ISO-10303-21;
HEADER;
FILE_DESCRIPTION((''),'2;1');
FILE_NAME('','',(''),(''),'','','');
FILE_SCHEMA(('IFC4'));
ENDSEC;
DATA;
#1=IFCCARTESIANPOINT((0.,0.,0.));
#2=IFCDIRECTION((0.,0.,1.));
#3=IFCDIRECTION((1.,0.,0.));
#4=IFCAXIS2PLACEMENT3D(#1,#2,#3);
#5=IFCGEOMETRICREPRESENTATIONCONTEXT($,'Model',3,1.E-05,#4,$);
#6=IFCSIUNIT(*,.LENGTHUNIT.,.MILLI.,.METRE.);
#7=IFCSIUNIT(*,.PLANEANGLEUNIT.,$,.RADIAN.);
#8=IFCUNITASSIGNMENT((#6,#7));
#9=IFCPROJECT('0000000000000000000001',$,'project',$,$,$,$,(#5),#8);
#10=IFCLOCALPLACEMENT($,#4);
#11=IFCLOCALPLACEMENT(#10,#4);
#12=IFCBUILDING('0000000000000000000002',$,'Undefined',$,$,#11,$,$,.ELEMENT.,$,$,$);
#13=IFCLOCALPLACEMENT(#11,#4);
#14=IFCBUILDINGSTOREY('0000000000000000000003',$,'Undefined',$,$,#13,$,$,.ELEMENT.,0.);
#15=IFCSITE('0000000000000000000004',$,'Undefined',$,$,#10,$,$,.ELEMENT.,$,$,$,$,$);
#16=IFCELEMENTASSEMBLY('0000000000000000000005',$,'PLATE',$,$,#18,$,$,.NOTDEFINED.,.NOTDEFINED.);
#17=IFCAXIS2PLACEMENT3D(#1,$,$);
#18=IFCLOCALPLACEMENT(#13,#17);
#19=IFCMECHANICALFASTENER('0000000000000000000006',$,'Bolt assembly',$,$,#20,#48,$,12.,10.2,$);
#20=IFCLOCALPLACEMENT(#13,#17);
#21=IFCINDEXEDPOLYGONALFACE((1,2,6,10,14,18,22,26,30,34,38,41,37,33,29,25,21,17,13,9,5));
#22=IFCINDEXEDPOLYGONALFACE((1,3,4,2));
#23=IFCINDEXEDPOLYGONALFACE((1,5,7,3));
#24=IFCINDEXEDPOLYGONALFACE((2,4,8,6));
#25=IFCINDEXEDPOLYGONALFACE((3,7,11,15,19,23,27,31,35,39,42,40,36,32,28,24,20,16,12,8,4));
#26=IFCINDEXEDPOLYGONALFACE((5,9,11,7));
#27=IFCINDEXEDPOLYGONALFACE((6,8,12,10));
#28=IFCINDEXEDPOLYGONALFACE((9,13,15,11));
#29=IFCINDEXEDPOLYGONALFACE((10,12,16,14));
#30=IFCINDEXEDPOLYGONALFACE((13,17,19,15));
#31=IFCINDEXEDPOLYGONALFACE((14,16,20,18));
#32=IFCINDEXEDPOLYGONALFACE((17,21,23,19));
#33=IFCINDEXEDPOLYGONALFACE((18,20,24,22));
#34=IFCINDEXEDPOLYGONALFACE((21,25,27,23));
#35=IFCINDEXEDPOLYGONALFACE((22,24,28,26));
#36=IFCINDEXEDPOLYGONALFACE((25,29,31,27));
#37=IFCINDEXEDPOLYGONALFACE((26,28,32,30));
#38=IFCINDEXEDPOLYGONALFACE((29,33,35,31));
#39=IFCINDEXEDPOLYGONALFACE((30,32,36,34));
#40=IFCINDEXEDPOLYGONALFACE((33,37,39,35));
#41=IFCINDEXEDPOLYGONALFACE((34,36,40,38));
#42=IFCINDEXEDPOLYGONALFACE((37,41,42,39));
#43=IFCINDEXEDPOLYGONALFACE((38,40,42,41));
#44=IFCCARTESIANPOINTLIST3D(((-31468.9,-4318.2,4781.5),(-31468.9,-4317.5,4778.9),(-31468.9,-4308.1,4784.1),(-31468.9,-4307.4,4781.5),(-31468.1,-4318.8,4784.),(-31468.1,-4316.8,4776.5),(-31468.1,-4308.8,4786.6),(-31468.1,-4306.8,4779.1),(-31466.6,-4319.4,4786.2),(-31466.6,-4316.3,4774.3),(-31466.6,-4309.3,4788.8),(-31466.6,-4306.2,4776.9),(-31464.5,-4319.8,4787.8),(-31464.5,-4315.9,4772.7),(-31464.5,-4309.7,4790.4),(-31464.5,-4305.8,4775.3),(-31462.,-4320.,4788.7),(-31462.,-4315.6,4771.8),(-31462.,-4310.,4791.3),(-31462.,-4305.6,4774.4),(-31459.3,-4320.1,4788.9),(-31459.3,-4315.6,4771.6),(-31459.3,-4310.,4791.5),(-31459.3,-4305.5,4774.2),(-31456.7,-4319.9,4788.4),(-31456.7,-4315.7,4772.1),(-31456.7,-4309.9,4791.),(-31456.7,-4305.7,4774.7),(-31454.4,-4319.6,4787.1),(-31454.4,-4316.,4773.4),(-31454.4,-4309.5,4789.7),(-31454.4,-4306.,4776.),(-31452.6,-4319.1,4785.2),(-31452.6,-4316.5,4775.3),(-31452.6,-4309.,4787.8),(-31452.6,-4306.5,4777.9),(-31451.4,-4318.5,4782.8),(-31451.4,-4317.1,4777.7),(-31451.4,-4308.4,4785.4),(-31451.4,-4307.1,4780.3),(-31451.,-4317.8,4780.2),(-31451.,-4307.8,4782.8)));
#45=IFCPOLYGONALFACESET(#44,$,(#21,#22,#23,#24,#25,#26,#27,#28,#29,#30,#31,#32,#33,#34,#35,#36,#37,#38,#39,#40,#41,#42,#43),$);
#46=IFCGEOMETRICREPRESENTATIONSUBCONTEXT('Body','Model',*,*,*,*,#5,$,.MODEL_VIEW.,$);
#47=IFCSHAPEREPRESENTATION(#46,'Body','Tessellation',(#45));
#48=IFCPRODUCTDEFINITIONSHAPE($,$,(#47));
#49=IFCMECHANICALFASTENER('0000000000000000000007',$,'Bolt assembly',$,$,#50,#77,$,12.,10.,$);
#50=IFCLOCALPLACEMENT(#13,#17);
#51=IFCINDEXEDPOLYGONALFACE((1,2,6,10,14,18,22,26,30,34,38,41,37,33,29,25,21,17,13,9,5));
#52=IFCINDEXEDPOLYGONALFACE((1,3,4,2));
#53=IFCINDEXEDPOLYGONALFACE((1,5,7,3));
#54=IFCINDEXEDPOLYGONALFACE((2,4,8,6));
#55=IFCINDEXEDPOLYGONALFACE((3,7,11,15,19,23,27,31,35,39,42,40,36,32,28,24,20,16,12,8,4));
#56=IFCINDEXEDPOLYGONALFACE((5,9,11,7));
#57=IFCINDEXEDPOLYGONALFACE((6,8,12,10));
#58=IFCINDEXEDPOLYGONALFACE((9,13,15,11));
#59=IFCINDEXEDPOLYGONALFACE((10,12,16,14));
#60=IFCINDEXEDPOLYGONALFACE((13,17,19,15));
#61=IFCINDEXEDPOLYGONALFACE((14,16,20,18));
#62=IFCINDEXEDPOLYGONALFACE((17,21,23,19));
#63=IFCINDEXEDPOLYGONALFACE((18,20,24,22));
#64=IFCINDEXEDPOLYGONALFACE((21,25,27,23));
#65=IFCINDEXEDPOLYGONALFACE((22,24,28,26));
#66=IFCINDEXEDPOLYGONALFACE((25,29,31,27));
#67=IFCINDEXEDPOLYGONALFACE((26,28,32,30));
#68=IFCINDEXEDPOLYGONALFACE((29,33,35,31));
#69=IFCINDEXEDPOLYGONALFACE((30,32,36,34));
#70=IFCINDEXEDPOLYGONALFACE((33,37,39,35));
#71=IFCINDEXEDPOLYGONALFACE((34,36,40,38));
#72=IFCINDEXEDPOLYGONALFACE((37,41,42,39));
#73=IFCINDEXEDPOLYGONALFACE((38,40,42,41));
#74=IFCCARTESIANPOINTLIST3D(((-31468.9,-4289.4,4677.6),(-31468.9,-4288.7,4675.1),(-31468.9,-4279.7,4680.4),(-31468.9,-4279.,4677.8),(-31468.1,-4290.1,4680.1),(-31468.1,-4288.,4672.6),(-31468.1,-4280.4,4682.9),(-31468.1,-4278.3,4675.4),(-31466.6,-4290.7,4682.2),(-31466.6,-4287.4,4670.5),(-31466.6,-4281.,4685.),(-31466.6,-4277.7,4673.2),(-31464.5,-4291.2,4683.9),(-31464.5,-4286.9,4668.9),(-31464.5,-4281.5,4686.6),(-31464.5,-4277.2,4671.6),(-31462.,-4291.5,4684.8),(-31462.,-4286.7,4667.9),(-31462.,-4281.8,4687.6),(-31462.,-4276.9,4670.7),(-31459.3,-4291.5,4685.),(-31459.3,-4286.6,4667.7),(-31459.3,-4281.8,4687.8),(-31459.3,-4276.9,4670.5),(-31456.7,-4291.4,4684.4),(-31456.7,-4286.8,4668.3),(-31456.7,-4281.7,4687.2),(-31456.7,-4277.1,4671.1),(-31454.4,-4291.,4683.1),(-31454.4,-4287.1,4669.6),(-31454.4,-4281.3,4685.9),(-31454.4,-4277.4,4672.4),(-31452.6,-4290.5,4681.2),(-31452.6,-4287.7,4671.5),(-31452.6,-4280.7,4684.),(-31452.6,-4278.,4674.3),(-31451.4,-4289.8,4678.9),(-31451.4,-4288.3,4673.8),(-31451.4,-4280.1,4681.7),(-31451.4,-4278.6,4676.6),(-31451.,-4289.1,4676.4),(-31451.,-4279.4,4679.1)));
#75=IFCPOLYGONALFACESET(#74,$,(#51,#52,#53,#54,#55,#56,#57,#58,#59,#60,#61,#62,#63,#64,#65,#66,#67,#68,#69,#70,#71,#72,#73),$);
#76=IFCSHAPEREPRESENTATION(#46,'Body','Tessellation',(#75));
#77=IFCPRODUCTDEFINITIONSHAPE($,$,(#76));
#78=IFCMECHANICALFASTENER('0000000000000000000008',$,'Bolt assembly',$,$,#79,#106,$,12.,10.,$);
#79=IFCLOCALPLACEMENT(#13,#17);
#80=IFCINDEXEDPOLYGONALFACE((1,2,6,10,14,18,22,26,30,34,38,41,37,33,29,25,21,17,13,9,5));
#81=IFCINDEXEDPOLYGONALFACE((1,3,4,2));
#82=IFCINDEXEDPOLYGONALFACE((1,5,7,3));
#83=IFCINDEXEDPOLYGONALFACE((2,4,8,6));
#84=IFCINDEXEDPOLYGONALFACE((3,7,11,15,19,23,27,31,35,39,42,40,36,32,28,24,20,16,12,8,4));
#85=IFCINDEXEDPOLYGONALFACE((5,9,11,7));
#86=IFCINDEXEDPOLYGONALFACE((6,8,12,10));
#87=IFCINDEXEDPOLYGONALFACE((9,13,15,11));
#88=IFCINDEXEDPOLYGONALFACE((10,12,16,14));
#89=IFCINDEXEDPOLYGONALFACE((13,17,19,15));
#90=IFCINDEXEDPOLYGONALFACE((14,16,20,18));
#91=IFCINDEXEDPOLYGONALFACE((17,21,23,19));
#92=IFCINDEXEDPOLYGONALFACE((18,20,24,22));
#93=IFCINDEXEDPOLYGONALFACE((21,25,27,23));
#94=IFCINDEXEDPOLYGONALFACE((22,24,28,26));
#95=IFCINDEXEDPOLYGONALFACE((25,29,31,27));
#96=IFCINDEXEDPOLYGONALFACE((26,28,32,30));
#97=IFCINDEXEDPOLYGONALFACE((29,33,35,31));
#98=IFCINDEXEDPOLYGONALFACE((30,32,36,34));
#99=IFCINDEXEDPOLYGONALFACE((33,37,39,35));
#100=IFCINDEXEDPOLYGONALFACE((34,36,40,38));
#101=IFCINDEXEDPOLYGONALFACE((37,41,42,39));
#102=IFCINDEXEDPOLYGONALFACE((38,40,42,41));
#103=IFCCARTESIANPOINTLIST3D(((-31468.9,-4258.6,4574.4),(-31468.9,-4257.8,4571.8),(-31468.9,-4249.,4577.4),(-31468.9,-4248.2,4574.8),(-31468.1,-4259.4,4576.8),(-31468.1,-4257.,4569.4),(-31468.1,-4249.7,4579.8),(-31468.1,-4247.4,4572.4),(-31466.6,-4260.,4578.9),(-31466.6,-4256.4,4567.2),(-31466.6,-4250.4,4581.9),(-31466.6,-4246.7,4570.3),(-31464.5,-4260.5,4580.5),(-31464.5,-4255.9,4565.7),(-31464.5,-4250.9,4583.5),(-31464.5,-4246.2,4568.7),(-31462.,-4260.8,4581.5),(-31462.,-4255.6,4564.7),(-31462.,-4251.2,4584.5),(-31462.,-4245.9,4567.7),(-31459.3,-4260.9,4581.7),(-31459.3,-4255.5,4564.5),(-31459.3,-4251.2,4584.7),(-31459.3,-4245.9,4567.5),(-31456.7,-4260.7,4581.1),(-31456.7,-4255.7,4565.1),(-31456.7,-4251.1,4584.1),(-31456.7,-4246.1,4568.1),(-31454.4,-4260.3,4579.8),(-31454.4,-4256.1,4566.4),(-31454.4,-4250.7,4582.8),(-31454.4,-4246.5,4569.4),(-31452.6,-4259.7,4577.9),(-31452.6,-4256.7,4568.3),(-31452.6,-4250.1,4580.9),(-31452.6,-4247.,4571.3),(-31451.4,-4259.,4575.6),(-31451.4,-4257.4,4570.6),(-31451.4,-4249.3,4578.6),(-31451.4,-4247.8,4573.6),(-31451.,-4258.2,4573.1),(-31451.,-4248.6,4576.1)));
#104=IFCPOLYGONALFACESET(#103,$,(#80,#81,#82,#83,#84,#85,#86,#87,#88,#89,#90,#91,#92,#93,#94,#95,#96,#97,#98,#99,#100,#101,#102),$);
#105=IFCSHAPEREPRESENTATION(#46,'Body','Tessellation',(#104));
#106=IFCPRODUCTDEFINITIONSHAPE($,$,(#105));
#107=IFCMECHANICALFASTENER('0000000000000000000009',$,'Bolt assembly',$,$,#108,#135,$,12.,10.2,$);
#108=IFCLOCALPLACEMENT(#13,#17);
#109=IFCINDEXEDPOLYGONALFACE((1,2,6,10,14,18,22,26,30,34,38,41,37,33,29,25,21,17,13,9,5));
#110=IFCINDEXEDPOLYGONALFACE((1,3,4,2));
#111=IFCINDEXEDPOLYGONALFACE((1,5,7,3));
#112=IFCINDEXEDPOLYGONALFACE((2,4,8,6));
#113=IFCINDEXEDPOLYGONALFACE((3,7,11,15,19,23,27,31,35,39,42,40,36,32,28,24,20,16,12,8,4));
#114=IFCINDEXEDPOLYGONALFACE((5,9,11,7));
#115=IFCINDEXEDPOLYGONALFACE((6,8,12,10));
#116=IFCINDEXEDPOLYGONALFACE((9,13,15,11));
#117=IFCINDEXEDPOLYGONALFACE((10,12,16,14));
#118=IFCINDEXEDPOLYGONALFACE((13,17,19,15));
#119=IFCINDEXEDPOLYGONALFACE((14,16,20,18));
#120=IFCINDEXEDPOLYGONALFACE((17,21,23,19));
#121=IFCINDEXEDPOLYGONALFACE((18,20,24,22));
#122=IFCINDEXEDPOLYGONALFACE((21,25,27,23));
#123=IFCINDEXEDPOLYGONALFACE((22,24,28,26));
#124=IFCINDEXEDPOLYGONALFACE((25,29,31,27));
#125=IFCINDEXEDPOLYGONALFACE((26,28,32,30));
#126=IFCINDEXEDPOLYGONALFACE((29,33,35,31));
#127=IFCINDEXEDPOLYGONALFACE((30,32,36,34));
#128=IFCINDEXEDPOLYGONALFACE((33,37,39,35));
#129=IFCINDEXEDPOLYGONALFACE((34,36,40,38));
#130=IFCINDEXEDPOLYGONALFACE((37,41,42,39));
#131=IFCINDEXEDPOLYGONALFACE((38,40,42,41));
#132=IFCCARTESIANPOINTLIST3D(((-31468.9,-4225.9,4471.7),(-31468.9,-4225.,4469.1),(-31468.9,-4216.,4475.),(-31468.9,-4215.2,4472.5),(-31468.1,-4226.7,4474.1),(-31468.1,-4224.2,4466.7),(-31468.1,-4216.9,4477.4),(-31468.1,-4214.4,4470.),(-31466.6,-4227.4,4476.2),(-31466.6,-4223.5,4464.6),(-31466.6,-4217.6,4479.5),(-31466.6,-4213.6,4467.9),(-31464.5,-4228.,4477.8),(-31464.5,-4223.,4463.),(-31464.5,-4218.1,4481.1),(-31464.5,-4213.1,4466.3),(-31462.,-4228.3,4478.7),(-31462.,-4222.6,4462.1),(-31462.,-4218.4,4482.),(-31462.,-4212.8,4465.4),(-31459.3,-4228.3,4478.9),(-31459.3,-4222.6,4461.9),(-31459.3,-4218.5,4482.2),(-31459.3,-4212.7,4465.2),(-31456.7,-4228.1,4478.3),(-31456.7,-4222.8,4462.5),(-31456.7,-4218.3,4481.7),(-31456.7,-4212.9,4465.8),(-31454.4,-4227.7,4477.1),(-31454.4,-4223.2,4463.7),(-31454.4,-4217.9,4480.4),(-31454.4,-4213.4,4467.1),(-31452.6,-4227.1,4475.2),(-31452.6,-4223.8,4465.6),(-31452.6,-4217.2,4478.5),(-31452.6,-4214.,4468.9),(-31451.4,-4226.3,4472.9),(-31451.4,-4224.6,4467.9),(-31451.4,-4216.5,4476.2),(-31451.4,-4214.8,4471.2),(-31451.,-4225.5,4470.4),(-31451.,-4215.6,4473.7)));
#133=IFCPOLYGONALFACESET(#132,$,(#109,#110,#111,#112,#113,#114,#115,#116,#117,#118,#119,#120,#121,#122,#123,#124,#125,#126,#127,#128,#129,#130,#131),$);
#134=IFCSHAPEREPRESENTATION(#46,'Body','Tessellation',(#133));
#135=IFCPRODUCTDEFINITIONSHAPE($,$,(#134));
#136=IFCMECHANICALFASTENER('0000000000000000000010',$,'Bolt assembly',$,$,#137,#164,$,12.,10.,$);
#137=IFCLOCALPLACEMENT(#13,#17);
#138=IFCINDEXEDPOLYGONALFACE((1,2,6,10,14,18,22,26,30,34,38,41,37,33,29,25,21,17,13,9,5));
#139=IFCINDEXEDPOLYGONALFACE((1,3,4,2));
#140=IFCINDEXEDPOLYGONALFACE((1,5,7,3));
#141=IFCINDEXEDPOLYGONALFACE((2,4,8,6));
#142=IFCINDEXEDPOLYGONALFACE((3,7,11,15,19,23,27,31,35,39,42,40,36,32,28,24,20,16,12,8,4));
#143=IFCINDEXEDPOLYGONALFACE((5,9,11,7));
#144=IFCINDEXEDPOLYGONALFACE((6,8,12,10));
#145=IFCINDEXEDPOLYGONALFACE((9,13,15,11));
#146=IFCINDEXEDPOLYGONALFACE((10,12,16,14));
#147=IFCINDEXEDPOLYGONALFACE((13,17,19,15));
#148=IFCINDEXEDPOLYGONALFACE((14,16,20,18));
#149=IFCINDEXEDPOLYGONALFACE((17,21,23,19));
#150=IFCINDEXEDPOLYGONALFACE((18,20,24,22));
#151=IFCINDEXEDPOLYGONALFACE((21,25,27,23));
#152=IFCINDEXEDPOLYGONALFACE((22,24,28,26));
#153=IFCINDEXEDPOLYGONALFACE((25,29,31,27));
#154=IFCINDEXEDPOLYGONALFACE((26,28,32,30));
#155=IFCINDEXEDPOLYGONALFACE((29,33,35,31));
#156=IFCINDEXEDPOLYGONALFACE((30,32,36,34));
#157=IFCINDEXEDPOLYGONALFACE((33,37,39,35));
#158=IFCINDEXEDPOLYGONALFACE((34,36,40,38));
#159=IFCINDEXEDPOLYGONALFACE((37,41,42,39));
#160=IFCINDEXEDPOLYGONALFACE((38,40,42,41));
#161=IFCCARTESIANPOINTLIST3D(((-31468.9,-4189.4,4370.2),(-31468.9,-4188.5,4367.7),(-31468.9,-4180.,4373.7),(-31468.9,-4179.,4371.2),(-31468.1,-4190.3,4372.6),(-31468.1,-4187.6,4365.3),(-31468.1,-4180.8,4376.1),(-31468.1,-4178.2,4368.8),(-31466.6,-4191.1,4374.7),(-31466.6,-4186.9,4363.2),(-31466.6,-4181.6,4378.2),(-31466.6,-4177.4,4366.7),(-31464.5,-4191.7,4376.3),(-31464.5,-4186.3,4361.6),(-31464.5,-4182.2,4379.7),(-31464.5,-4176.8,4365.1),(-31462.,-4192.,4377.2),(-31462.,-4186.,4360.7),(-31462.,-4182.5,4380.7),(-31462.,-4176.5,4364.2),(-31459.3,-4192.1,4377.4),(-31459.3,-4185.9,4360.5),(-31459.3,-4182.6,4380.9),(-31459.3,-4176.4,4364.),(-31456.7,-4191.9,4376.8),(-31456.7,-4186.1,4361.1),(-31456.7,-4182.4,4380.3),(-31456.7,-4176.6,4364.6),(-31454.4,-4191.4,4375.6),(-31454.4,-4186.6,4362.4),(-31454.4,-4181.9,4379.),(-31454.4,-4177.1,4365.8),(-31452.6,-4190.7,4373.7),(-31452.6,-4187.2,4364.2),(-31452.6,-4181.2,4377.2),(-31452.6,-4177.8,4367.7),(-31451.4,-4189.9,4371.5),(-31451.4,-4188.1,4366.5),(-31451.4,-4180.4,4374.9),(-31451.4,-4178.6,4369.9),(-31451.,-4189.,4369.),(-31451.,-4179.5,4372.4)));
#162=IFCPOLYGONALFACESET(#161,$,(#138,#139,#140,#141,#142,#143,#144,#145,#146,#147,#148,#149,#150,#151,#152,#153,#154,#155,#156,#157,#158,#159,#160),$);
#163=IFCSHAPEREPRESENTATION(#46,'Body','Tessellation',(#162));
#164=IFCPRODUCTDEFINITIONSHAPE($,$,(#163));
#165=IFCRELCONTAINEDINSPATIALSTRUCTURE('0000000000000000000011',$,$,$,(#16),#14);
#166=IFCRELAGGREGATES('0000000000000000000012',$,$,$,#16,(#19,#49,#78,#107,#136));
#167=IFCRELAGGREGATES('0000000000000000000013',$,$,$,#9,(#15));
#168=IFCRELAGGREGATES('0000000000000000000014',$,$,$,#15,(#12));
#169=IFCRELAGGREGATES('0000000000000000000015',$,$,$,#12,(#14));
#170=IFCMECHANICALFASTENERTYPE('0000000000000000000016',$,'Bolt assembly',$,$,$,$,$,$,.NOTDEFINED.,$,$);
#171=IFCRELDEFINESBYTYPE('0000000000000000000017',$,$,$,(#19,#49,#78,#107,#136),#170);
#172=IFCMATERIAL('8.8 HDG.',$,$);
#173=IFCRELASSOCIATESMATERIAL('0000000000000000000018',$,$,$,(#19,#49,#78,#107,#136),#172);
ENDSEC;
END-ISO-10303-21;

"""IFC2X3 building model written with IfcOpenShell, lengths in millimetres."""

from ifc_helpers import new_model, si_unit, frame, origin_with_axes, origin_2d_with_axis, place, context, subcontext, project, spatial, circle, extrude, source, transform, mapped, material, type_object, element, aggregate, save


model = new_model("IFC2X3")

# Units and contexts
model_context = context("Model", 3, precision=1e-05, world=origin_with_axes())
body_context = subcontext(model_context, "Body", "Model", "MODEL_VIEW")
ifc_project = project(units=[si_unit("LENGTHUNIT", "METRE", prefix="MILLI"), si_unit("PLANEANGLEUNIT", "RADIAN")], contexts=[model_context])

# Site, building, storey
site_placement = place(None, origin_with_axes())
site = spatial("IfcSite", under=ifc_project, at=site_placement, Name="Undefined", CompositionType="ELEMENT")
building_placement = place(site_placement, origin_with_axes())
building = spatial("IfcBuilding", under=site, at=building_placement, Name="Undefined", CompositionType="ELEMENT")
storey_placement = place(building_placement, origin_with_axes())
storey = spatial("IfcBuildingStorey", under=building, at=storey_placement, Name="Undefined", CompositionType="ELEMENT", Elevation=0.0)

# Element assembly
assembly_1_placement = place(storey_placement, origin_with_axes())
assembly_1 = element("IfcElementAssembly", 1, at=assembly_1_placement, inside=storey, Name="PLATE", AssemblyPlace="NOTDEFINED", PredefinedType="NOTDEFINED")

# Shared definitions
mechanical_fastener_type = type_object("IfcMechanicalFastenerType", Name="Bolt assembly")

# Mechanical fasteners
ifc_material_1 = material(Name="8.8 HDG.")
shared_shape_1 = source(origin_with_axes(), body_context, "Body", "SweptSolid", [
    extrude(circle(Radius=9.0, at=origin_2d_with_axis()), frame((0.0, 0.3, 0.0), z_axis=(0.0, 1.0, 0.0), x_axis=(1.0, 0.0, 0.0)), (0.0, 0.0, 1.0), 10.4),
])
mechanical_fastener_1_placement = place(assembly_1_placement, frame((-31460.0, -4318.1, 4780.2), z_axis=(0.000001, -0.25103, 0.967979), x_axis=(1.0, 0.0, -0.000001)))
mechanical_fastener_1 = element("IfcMechanicalFastener", 2, at=mechanical_fastener_1_placement, type_object=mechanical_fastener_type, material=ifc_material_1, Name="Bolt assembly", NominalDiameter=12.0, NominalLength=10.2, context=body_context, shape_type="MappedRepresentation", body=[
    mapped(shared_shape_1, transform((0.0, 0.0, 0.0))),
])
shared_shape_2 = source(origin_with_axes(), body_context, "Body", "SweptSolid", [
    extrude(circle(Radius=9.0, at=origin_2d_with_axis()), frame((0.0, 0.8, 0.0), z_axis=(0.0, 1.0, 0.0), x_axis=(1.0, 0.0, 0.0)), (0.0, 0.0, 1.0), 10.1),
])
mechanical_fastener_2_placement = place(assembly_1_placement, frame((-31460.0, -4289.8, 4676.2), z_axis=(0.000001, -0.274347, 0.961631), x_axis=(1.0, 0.0, -0.000001)))
mechanical_fastener_2 = element("IfcMechanicalFastener", 3, at=mechanical_fastener_2_placement, type_object=mechanical_fastener_type, material=ifc_material_1, Name="Bolt assembly", NominalDiameter=12.0, NominalLength=10.0, context=body_context, shape_type="MappedRepresentation", body=[
    mapped(shared_shape_2, transform((0.0, 0.0, 0.0))),
])
shared_shape_3 = source(origin_with_axes(), body_context, "Body", "SweptSolid", [
    extrude(circle(Radius=9.0, at=origin_2d_with_axis()), frame((0.0, 0.8, 0.0), z_axis=(0.0, 1.0, 0.0), x_axis=(1.0, 0.0, 0.0)), (0.0, 0.0, 1.0), 10.1),
])
mechanical_fastener_3_placement = place(assembly_1_placement, frame((-31460.0, -4259.0, 4572.9), z_axis=(0.000001, -0.297503, 0.954721), x_axis=(1.0, 0.0, -0.000001)))
mechanical_fastener_3 = element("IfcMechanicalFastener", 4, at=mechanical_fastener_3_placement, type_object=mechanical_fastener_type, material=ifc_material_1, Name="Bolt assembly", NominalDiameter=12.0, NominalLength=10.0, context=body_context, shape_type="MappedRepresentation", body=[
    mapped(shared_shape_3, transform((0.0, 0.0, 0.0))),
])
shared_shape_4 = source(origin_with_axes(), body_context, "Body", "SweptSolid", [
    extrude(circle(Radius=9.0, at=origin_2d_with_axis()), frame((0.0, 0.2, 0.0), z_axis=(0.0, 1.0, 0.0), x_axis=(1.0, 0.0, 0.0)), (0.0, 0.0, 1.0), 10.4),
])
mechanical_fastener_4_placement = place(assembly_1_placement, frame((-31460.0, -4225.7, 4470.3), z_axis=(0.000001, -0.320486, 0.947253), x_axis=(1.0, 0.0, -0.000001)))
mechanical_fastener_4 = element("IfcMechanicalFastener", 5, at=mechanical_fastener_4_placement, type_object=mechanical_fastener_type, material=ifc_material_1, Name="Bolt assembly", NominalDiameter=12.0, NominalLength=10.2, context=body_context, shape_type="MappedRepresentation", body=[
    mapped(shared_shape_4, transform((0.0, 0.0, 0.0))),
])
shared_shape_5 = source(origin_with_axes(), body_context, "Body", "SweptSolid", [
    extrude(circle(Radius=9.0, at=origin_2d_with_axis()), frame((0.0, 0.9, 0.0), z_axis=(0.0, 1.0, 0.0), x_axis=(1.0, 0.0, 0.0)), (0.0, 0.0, 1.0), 10.1),
])
mechanical_fastener_5_placement = place(assembly_1_placement, frame((-31460.0, -4189.9, 4368.6), z_axis=(0.000001, -0.343282, 0.939233), x_axis=(1.0, 0.0, -0.000001)))
mechanical_fastener_5 = element("IfcMechanicalFastener", 6, at=mechanical_fastener_5_placement, type_object=mechanical_fastener_type, material=ifc_material_1, Name="Bolt assembly", NominalDiameter=12.0, NominalLength=10.0, context=body_context, shape_type="MappedRepresentation", body=[
    mapped(shared_shape_5, transform((0.0, 0.0, 0.0))),
])
aggregate(assembly_1, [mechanical_fastener_1, mechanical_fastener_2, mechanical_fastener_3, mechanical_fastener_4, mechanical_fastener_5])

save(model, "model.ifc")
